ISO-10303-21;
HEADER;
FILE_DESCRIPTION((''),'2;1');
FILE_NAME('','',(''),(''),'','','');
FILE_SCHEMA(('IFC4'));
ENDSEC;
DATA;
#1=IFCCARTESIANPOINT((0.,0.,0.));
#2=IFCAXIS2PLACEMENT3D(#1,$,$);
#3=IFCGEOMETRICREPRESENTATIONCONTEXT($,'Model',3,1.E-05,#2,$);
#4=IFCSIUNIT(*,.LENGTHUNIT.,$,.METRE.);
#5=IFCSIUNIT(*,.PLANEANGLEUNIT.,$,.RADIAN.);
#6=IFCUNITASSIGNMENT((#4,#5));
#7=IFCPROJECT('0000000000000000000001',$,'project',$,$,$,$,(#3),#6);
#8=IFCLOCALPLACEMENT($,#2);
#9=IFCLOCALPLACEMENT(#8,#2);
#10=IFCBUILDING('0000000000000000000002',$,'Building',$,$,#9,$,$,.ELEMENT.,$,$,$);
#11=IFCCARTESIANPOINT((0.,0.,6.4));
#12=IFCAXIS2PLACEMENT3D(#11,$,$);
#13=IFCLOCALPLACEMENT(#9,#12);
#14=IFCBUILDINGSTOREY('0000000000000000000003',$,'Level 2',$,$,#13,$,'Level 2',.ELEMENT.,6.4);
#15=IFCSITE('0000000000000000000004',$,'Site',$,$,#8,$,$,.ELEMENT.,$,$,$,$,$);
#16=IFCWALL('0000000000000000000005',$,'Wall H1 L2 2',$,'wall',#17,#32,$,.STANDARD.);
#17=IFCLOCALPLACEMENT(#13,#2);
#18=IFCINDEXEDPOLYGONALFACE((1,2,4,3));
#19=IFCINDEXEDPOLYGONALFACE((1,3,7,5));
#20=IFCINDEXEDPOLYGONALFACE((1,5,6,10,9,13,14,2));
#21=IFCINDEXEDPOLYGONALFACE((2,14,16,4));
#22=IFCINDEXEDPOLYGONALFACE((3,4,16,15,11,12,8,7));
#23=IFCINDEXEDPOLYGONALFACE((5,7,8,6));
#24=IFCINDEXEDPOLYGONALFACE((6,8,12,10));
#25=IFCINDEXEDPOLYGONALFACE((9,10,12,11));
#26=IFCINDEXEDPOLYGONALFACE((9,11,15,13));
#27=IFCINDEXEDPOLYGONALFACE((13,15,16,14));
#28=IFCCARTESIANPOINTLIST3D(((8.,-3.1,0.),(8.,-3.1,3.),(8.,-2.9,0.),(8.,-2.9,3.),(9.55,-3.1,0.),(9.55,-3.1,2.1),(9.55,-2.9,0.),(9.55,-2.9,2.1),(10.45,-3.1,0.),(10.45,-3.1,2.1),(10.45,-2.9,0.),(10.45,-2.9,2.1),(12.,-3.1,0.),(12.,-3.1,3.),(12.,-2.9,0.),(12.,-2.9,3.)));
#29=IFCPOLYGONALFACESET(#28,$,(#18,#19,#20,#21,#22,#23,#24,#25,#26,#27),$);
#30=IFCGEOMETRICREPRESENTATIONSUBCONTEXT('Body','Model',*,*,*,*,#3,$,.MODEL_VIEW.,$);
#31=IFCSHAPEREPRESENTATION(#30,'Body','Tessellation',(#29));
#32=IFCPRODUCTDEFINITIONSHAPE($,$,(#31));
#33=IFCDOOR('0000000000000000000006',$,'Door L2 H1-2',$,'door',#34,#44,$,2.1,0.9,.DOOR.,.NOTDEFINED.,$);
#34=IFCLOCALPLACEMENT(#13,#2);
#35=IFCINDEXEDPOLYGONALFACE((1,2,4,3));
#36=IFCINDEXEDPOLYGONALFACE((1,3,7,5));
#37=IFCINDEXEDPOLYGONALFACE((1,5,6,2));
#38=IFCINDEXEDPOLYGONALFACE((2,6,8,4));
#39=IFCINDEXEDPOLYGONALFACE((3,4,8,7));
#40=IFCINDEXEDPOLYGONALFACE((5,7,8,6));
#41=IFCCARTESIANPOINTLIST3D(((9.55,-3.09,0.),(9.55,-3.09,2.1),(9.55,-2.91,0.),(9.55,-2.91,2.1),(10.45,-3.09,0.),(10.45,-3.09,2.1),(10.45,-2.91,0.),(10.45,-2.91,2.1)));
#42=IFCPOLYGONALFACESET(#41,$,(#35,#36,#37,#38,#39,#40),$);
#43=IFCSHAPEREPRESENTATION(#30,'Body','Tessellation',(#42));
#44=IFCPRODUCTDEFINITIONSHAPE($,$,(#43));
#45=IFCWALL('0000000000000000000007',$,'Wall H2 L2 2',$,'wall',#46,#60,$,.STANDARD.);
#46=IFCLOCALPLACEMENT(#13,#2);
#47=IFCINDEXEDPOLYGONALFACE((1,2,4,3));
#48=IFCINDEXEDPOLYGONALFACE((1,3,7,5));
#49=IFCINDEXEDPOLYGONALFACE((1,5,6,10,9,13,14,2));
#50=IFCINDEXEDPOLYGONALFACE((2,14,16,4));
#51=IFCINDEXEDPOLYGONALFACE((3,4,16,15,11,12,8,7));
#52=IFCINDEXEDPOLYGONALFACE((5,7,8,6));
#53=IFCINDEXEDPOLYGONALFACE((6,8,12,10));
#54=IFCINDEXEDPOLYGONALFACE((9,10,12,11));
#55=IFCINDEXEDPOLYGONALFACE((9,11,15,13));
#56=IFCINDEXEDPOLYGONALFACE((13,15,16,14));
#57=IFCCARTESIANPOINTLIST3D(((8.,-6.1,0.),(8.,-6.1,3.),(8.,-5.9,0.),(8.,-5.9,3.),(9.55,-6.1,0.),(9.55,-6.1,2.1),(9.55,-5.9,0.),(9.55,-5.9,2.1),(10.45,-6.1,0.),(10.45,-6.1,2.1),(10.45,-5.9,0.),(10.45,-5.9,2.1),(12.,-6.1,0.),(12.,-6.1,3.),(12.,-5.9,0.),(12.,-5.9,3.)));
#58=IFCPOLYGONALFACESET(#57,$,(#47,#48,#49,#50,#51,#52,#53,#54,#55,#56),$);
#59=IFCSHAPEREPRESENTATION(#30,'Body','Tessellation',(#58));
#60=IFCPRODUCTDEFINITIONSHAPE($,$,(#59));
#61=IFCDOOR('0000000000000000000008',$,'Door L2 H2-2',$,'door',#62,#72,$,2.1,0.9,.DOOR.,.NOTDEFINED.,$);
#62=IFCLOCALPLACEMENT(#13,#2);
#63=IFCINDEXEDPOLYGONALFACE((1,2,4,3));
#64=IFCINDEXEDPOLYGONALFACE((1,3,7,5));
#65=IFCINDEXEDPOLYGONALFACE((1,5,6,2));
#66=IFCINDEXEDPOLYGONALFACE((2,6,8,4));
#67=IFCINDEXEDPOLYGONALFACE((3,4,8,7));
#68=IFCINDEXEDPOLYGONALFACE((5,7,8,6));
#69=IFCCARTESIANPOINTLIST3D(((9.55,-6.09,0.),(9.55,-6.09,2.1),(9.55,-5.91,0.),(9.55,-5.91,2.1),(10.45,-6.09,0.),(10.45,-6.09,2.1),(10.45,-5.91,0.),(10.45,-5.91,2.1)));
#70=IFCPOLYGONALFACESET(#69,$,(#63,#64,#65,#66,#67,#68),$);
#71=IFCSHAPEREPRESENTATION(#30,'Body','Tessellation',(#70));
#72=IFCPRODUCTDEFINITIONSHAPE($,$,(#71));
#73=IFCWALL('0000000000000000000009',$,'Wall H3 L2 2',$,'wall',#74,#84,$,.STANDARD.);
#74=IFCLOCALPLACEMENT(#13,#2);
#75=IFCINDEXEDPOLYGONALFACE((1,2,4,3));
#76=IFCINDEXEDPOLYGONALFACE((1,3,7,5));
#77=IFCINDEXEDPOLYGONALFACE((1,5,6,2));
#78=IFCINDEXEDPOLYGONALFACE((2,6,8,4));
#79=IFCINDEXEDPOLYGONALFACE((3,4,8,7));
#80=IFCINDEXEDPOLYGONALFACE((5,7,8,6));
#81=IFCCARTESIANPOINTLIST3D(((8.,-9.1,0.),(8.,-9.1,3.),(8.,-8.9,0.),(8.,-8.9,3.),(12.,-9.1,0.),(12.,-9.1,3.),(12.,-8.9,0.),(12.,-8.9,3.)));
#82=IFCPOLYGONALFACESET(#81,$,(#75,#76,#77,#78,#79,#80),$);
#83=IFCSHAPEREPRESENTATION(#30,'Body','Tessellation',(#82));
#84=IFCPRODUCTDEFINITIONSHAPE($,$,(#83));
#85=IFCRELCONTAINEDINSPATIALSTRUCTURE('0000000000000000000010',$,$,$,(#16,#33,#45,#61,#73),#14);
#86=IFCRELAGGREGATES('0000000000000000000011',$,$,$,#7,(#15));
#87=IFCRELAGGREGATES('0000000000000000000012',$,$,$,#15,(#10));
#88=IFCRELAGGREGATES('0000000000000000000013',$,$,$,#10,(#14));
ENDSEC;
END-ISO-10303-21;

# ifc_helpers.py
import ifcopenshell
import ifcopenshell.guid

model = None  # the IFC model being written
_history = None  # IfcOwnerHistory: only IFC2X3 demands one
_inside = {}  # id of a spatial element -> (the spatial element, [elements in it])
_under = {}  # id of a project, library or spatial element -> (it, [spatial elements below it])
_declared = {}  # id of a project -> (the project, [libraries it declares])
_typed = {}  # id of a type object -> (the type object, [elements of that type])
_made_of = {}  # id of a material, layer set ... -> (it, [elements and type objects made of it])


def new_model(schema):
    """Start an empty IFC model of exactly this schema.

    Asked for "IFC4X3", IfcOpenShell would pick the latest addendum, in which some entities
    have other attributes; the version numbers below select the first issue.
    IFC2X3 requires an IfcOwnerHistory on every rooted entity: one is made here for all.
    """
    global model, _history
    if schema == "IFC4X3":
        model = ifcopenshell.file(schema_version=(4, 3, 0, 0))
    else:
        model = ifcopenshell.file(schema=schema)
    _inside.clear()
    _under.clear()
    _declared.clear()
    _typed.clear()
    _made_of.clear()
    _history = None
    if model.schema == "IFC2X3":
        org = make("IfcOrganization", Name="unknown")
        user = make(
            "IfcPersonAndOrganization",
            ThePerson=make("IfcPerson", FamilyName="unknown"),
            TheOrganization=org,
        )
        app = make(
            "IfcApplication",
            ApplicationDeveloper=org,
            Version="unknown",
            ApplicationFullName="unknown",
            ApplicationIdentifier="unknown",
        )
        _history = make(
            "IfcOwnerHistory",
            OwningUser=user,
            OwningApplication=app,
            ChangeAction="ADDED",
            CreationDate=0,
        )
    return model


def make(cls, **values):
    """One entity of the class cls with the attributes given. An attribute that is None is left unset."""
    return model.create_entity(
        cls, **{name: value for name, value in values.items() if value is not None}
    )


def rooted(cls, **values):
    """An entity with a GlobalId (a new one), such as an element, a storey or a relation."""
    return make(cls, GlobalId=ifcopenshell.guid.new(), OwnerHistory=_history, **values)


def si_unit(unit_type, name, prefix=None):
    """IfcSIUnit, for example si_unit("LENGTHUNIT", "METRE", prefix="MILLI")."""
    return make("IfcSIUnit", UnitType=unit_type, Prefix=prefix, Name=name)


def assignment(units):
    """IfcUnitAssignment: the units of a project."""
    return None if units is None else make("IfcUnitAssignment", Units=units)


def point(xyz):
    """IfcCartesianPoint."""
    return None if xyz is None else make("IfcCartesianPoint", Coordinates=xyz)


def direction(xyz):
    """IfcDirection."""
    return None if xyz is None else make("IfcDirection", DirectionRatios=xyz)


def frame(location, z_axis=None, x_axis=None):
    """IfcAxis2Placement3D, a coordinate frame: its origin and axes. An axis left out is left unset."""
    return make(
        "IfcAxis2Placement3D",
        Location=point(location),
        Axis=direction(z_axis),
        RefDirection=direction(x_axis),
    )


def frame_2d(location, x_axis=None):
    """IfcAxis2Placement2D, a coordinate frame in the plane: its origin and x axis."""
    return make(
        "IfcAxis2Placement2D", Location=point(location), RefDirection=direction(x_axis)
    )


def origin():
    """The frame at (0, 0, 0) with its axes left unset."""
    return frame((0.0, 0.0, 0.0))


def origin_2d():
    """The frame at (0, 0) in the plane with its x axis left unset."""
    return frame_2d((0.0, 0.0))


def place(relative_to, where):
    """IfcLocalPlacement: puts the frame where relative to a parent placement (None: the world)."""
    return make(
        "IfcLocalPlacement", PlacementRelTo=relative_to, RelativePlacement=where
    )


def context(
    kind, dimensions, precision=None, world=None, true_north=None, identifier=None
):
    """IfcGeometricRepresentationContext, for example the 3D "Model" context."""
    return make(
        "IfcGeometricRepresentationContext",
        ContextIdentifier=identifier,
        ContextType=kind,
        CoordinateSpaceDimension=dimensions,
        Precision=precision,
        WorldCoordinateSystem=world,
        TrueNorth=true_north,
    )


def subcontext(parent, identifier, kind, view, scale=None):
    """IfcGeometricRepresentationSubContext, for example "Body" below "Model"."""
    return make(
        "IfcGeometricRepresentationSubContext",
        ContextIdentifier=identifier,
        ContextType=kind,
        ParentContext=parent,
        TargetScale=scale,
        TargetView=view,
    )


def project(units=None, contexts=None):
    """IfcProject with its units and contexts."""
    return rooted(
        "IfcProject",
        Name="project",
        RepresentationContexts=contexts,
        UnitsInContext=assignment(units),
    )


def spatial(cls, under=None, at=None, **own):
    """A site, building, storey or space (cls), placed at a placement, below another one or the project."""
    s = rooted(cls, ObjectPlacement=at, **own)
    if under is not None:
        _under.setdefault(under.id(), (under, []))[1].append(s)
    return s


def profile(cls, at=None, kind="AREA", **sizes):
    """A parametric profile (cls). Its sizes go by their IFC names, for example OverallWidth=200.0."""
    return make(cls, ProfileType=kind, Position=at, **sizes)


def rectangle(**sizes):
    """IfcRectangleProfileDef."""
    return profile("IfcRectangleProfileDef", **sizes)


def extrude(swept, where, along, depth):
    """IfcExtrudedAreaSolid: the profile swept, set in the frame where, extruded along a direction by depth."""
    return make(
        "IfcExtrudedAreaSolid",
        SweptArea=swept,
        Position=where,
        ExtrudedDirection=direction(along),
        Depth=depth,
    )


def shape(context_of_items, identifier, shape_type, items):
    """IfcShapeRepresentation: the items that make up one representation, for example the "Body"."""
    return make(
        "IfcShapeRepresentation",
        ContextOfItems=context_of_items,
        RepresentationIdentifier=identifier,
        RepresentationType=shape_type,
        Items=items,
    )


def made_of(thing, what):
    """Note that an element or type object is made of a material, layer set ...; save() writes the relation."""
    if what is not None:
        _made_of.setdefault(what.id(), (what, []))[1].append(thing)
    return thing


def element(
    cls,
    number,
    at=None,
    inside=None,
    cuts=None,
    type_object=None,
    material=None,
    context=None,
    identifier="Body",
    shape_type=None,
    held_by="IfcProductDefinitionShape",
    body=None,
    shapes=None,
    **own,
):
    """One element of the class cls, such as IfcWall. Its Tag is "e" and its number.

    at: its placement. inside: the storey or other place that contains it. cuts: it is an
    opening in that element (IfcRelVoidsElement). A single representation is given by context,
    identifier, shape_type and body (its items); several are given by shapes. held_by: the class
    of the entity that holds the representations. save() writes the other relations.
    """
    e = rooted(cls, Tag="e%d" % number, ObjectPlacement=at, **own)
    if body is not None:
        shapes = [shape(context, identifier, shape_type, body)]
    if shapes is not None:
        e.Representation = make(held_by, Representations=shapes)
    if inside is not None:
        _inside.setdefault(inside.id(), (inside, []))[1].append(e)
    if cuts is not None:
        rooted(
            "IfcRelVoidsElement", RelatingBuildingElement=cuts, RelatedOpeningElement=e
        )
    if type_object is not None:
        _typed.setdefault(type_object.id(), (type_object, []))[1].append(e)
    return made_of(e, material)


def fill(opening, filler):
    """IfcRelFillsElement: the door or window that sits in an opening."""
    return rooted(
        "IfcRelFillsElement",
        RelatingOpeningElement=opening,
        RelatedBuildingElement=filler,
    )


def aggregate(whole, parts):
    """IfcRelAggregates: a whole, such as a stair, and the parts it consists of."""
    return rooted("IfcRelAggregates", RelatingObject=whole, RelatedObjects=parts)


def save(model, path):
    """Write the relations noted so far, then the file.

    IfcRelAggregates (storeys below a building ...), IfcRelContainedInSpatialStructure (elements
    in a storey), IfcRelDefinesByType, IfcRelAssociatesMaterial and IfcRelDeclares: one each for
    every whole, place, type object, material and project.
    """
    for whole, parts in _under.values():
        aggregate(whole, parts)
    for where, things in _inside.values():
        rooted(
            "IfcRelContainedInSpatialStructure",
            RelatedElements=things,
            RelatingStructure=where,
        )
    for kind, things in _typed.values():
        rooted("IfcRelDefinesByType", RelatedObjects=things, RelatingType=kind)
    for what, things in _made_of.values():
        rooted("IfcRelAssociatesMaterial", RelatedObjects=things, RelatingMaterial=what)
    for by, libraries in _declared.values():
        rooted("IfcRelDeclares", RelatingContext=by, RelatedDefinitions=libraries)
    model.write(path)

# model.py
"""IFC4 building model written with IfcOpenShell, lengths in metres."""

from ifc_helpers import new_model, si_unit, frame, frame_2d, origin, origin_2d, place, context, subcontext, project, spatial, rectangle, extrude, element, fill, save


model = new_model("IFC4")

# Units and contexts
model_context = context("Model", 3, precision=1e-05, world=origin())
body_context = subcontext(model_context, "Body", "Model", "MODEL_VIEW")
ifc_project = project(units=[si_unit("LENGTHUNIT", "METRE"), si_unit("PLANEANGLEUNIT", "RADIAN")], contexts=[model_context])

# Site, building, storey
site_placement = place(None, origin())
site = spatial("IfcSite", under=ifc_project, at=site_placement, Name="Site", CompositionType="ELEMENT")
building_placement = place(site_placement, origin())
building = spatial("IfcBuilding", under=site, at=building_placement, Name="Building", CompositionType="ELEMENT")
storey_placement = place(building_placement, frame((0.0, 0.0, 6.4)))
storey = spatial("IfcBuildingStorey", under=building, at=storey_placement, Name="Level 2", LongName="Level 2", CompositionType="ELEMENT", Elevation=6.4)

# Walls, openings, doors
wall_1_placement = place(storey_placement, frame((8.0, -3.0, 0.0), z_axis=(0.0, 0.0, 1.0), x_axis=(1.0, 0.0, 0.0)))
wall_1 = element("IfcWall", 1, at=wall_1_placement, inside=storey, Name="Wall H1 L2 2", ObjectType="wall", PredefinedType="STANDARD", context=body_context, shape_type="SweptSolid", body=[
    extrude(rectangle(XDim=4.0, YDim=0.2, at=frame_2d((2.0, 0.0))), origin(), (0.0, 0.0, 1.0), 3.0),
])
opening_1_placement = place(storey_placement, frame((10.0, -3.0, 0.0), z_axis=(0.0, 0.0, 1.0), x_axis=(1.0, 0.0, 0.0)))
opening_1 = element("IfcOpeningElement", 2, at=opening_1_placement, cuts=wall_1, ObjectType="Opening", PredefinedType="OPENING", context=body_context, shape_type="SweptSolid", body=[
    extrude(rectangle(XDim=0.9, YDim=0.22, at=origin_2d()), origin(), (0.0, 0.0, 1.0), 2.1),
])
door_1_placement = place(storey_placement, frame((10.0, -3.0, 0.0), z_axis=(0.0, 0.0, 1.0), x_axis=(1.0, 0.0, 0.0)))
door_1 = element("IfcDoor", 3, at=door_1_placement, inside=storey, Name="Door L2 H1-2", ObjectType="door", OperationType="NOTDEFINED", OverallHeight=2.1, OverallWidth=0.9, PredefinedType="DOOR", context=body_context, shape_type="SweptSolid", body=[
    extrude(rectangle(XDim=0.9, YDim=0.18, at=origin_2d()), origin(), (0.0, 0.0, 1.0), 2.1),
])
fill(opening_1, door_1)
wall_2_placement = place(storey_placement, frame((8.0, -6.0, 0.0), z_axis=(0.0, 0.0, 1.0), x_axis=(1.0, 0.0, 0.0)))
wall_2 = element("IfcWall", 4, at=wall_2_placement, inside=storey, Name="Wall H2 L2 2", ObjectType="wall", PredefinedType="STANDARD", context=body_context, shape_type="SweptSolid", body=[
    extrude(rectangle(XDim=4.0, YDim=0.2, at=frame_2d((2.0, 0.0))), origin(), (0.0, 0.0, 1.0), 3.0),
])
opening_2_placement = place(storey_placement, frame((10.0, -6.0, 0.0), z_axis=(0.0, 0.0, 1.0), x_axis=(1.0, 0.0, 0.0)))
opening_2 = element("IfcOpeningElement", 5, at=opening_2_placement, cuts=wall_2, ObjectType="Opening", PredefinedType="OPENING", context=body_context, shape_type="SweptSolid", body=[
    extrude(rectangle(XDim=0.9, YDim=0.22, at=origin_2d()), origin(), (0.0, 0.0, 1.0), 2.1),
])
door_2_placement = place(storey_placement, frame((10.0, -6.0, 0.0), z_axis=(0.0, 0.0, 1.0), x_axis=(1.0, 0.0, 0.0)))
door_2 = element("IfcDoor", 6, at=door_2_placement, inside=storey, Name="Door L2 H2-2", ObjectType="door", OperationType="NOTDEFINED", OverallHeight=2.1, OverallWidth=0.9, PredefinedType="DOOR", context=body_context, shape_type="SweptSolid", body=[
    extrude(rectangle(XDim=0.9, YDim=0.18, at=origin_2d()), origin(), (0.0, 0.0, 1.0), 2.1),
])
fill(opening_2, door_2)

# Wall
wall_3_placement = place(storey_placement, frame((8.0, -9.0, 0.0), z_axis=(0.0, 0.0, 1.0), x_axis=(1.0, 0.0, 0.0)))
element("IfcWall", 7, at=wall_3_placement, inside=storey, Name="Wall H3 L2 2", ObjectType="wall", PredefinedType="STANDARD", context=body_context, shape_type="SweptSolid", body=[
    extrude(rectangle(XDim=4.0, YDim=0.2, at=frame_2d((2.0, 0.0))), origin(), (0.0, 0.0, 1.0), 3.0),
])

save(model, "model.ifc")
